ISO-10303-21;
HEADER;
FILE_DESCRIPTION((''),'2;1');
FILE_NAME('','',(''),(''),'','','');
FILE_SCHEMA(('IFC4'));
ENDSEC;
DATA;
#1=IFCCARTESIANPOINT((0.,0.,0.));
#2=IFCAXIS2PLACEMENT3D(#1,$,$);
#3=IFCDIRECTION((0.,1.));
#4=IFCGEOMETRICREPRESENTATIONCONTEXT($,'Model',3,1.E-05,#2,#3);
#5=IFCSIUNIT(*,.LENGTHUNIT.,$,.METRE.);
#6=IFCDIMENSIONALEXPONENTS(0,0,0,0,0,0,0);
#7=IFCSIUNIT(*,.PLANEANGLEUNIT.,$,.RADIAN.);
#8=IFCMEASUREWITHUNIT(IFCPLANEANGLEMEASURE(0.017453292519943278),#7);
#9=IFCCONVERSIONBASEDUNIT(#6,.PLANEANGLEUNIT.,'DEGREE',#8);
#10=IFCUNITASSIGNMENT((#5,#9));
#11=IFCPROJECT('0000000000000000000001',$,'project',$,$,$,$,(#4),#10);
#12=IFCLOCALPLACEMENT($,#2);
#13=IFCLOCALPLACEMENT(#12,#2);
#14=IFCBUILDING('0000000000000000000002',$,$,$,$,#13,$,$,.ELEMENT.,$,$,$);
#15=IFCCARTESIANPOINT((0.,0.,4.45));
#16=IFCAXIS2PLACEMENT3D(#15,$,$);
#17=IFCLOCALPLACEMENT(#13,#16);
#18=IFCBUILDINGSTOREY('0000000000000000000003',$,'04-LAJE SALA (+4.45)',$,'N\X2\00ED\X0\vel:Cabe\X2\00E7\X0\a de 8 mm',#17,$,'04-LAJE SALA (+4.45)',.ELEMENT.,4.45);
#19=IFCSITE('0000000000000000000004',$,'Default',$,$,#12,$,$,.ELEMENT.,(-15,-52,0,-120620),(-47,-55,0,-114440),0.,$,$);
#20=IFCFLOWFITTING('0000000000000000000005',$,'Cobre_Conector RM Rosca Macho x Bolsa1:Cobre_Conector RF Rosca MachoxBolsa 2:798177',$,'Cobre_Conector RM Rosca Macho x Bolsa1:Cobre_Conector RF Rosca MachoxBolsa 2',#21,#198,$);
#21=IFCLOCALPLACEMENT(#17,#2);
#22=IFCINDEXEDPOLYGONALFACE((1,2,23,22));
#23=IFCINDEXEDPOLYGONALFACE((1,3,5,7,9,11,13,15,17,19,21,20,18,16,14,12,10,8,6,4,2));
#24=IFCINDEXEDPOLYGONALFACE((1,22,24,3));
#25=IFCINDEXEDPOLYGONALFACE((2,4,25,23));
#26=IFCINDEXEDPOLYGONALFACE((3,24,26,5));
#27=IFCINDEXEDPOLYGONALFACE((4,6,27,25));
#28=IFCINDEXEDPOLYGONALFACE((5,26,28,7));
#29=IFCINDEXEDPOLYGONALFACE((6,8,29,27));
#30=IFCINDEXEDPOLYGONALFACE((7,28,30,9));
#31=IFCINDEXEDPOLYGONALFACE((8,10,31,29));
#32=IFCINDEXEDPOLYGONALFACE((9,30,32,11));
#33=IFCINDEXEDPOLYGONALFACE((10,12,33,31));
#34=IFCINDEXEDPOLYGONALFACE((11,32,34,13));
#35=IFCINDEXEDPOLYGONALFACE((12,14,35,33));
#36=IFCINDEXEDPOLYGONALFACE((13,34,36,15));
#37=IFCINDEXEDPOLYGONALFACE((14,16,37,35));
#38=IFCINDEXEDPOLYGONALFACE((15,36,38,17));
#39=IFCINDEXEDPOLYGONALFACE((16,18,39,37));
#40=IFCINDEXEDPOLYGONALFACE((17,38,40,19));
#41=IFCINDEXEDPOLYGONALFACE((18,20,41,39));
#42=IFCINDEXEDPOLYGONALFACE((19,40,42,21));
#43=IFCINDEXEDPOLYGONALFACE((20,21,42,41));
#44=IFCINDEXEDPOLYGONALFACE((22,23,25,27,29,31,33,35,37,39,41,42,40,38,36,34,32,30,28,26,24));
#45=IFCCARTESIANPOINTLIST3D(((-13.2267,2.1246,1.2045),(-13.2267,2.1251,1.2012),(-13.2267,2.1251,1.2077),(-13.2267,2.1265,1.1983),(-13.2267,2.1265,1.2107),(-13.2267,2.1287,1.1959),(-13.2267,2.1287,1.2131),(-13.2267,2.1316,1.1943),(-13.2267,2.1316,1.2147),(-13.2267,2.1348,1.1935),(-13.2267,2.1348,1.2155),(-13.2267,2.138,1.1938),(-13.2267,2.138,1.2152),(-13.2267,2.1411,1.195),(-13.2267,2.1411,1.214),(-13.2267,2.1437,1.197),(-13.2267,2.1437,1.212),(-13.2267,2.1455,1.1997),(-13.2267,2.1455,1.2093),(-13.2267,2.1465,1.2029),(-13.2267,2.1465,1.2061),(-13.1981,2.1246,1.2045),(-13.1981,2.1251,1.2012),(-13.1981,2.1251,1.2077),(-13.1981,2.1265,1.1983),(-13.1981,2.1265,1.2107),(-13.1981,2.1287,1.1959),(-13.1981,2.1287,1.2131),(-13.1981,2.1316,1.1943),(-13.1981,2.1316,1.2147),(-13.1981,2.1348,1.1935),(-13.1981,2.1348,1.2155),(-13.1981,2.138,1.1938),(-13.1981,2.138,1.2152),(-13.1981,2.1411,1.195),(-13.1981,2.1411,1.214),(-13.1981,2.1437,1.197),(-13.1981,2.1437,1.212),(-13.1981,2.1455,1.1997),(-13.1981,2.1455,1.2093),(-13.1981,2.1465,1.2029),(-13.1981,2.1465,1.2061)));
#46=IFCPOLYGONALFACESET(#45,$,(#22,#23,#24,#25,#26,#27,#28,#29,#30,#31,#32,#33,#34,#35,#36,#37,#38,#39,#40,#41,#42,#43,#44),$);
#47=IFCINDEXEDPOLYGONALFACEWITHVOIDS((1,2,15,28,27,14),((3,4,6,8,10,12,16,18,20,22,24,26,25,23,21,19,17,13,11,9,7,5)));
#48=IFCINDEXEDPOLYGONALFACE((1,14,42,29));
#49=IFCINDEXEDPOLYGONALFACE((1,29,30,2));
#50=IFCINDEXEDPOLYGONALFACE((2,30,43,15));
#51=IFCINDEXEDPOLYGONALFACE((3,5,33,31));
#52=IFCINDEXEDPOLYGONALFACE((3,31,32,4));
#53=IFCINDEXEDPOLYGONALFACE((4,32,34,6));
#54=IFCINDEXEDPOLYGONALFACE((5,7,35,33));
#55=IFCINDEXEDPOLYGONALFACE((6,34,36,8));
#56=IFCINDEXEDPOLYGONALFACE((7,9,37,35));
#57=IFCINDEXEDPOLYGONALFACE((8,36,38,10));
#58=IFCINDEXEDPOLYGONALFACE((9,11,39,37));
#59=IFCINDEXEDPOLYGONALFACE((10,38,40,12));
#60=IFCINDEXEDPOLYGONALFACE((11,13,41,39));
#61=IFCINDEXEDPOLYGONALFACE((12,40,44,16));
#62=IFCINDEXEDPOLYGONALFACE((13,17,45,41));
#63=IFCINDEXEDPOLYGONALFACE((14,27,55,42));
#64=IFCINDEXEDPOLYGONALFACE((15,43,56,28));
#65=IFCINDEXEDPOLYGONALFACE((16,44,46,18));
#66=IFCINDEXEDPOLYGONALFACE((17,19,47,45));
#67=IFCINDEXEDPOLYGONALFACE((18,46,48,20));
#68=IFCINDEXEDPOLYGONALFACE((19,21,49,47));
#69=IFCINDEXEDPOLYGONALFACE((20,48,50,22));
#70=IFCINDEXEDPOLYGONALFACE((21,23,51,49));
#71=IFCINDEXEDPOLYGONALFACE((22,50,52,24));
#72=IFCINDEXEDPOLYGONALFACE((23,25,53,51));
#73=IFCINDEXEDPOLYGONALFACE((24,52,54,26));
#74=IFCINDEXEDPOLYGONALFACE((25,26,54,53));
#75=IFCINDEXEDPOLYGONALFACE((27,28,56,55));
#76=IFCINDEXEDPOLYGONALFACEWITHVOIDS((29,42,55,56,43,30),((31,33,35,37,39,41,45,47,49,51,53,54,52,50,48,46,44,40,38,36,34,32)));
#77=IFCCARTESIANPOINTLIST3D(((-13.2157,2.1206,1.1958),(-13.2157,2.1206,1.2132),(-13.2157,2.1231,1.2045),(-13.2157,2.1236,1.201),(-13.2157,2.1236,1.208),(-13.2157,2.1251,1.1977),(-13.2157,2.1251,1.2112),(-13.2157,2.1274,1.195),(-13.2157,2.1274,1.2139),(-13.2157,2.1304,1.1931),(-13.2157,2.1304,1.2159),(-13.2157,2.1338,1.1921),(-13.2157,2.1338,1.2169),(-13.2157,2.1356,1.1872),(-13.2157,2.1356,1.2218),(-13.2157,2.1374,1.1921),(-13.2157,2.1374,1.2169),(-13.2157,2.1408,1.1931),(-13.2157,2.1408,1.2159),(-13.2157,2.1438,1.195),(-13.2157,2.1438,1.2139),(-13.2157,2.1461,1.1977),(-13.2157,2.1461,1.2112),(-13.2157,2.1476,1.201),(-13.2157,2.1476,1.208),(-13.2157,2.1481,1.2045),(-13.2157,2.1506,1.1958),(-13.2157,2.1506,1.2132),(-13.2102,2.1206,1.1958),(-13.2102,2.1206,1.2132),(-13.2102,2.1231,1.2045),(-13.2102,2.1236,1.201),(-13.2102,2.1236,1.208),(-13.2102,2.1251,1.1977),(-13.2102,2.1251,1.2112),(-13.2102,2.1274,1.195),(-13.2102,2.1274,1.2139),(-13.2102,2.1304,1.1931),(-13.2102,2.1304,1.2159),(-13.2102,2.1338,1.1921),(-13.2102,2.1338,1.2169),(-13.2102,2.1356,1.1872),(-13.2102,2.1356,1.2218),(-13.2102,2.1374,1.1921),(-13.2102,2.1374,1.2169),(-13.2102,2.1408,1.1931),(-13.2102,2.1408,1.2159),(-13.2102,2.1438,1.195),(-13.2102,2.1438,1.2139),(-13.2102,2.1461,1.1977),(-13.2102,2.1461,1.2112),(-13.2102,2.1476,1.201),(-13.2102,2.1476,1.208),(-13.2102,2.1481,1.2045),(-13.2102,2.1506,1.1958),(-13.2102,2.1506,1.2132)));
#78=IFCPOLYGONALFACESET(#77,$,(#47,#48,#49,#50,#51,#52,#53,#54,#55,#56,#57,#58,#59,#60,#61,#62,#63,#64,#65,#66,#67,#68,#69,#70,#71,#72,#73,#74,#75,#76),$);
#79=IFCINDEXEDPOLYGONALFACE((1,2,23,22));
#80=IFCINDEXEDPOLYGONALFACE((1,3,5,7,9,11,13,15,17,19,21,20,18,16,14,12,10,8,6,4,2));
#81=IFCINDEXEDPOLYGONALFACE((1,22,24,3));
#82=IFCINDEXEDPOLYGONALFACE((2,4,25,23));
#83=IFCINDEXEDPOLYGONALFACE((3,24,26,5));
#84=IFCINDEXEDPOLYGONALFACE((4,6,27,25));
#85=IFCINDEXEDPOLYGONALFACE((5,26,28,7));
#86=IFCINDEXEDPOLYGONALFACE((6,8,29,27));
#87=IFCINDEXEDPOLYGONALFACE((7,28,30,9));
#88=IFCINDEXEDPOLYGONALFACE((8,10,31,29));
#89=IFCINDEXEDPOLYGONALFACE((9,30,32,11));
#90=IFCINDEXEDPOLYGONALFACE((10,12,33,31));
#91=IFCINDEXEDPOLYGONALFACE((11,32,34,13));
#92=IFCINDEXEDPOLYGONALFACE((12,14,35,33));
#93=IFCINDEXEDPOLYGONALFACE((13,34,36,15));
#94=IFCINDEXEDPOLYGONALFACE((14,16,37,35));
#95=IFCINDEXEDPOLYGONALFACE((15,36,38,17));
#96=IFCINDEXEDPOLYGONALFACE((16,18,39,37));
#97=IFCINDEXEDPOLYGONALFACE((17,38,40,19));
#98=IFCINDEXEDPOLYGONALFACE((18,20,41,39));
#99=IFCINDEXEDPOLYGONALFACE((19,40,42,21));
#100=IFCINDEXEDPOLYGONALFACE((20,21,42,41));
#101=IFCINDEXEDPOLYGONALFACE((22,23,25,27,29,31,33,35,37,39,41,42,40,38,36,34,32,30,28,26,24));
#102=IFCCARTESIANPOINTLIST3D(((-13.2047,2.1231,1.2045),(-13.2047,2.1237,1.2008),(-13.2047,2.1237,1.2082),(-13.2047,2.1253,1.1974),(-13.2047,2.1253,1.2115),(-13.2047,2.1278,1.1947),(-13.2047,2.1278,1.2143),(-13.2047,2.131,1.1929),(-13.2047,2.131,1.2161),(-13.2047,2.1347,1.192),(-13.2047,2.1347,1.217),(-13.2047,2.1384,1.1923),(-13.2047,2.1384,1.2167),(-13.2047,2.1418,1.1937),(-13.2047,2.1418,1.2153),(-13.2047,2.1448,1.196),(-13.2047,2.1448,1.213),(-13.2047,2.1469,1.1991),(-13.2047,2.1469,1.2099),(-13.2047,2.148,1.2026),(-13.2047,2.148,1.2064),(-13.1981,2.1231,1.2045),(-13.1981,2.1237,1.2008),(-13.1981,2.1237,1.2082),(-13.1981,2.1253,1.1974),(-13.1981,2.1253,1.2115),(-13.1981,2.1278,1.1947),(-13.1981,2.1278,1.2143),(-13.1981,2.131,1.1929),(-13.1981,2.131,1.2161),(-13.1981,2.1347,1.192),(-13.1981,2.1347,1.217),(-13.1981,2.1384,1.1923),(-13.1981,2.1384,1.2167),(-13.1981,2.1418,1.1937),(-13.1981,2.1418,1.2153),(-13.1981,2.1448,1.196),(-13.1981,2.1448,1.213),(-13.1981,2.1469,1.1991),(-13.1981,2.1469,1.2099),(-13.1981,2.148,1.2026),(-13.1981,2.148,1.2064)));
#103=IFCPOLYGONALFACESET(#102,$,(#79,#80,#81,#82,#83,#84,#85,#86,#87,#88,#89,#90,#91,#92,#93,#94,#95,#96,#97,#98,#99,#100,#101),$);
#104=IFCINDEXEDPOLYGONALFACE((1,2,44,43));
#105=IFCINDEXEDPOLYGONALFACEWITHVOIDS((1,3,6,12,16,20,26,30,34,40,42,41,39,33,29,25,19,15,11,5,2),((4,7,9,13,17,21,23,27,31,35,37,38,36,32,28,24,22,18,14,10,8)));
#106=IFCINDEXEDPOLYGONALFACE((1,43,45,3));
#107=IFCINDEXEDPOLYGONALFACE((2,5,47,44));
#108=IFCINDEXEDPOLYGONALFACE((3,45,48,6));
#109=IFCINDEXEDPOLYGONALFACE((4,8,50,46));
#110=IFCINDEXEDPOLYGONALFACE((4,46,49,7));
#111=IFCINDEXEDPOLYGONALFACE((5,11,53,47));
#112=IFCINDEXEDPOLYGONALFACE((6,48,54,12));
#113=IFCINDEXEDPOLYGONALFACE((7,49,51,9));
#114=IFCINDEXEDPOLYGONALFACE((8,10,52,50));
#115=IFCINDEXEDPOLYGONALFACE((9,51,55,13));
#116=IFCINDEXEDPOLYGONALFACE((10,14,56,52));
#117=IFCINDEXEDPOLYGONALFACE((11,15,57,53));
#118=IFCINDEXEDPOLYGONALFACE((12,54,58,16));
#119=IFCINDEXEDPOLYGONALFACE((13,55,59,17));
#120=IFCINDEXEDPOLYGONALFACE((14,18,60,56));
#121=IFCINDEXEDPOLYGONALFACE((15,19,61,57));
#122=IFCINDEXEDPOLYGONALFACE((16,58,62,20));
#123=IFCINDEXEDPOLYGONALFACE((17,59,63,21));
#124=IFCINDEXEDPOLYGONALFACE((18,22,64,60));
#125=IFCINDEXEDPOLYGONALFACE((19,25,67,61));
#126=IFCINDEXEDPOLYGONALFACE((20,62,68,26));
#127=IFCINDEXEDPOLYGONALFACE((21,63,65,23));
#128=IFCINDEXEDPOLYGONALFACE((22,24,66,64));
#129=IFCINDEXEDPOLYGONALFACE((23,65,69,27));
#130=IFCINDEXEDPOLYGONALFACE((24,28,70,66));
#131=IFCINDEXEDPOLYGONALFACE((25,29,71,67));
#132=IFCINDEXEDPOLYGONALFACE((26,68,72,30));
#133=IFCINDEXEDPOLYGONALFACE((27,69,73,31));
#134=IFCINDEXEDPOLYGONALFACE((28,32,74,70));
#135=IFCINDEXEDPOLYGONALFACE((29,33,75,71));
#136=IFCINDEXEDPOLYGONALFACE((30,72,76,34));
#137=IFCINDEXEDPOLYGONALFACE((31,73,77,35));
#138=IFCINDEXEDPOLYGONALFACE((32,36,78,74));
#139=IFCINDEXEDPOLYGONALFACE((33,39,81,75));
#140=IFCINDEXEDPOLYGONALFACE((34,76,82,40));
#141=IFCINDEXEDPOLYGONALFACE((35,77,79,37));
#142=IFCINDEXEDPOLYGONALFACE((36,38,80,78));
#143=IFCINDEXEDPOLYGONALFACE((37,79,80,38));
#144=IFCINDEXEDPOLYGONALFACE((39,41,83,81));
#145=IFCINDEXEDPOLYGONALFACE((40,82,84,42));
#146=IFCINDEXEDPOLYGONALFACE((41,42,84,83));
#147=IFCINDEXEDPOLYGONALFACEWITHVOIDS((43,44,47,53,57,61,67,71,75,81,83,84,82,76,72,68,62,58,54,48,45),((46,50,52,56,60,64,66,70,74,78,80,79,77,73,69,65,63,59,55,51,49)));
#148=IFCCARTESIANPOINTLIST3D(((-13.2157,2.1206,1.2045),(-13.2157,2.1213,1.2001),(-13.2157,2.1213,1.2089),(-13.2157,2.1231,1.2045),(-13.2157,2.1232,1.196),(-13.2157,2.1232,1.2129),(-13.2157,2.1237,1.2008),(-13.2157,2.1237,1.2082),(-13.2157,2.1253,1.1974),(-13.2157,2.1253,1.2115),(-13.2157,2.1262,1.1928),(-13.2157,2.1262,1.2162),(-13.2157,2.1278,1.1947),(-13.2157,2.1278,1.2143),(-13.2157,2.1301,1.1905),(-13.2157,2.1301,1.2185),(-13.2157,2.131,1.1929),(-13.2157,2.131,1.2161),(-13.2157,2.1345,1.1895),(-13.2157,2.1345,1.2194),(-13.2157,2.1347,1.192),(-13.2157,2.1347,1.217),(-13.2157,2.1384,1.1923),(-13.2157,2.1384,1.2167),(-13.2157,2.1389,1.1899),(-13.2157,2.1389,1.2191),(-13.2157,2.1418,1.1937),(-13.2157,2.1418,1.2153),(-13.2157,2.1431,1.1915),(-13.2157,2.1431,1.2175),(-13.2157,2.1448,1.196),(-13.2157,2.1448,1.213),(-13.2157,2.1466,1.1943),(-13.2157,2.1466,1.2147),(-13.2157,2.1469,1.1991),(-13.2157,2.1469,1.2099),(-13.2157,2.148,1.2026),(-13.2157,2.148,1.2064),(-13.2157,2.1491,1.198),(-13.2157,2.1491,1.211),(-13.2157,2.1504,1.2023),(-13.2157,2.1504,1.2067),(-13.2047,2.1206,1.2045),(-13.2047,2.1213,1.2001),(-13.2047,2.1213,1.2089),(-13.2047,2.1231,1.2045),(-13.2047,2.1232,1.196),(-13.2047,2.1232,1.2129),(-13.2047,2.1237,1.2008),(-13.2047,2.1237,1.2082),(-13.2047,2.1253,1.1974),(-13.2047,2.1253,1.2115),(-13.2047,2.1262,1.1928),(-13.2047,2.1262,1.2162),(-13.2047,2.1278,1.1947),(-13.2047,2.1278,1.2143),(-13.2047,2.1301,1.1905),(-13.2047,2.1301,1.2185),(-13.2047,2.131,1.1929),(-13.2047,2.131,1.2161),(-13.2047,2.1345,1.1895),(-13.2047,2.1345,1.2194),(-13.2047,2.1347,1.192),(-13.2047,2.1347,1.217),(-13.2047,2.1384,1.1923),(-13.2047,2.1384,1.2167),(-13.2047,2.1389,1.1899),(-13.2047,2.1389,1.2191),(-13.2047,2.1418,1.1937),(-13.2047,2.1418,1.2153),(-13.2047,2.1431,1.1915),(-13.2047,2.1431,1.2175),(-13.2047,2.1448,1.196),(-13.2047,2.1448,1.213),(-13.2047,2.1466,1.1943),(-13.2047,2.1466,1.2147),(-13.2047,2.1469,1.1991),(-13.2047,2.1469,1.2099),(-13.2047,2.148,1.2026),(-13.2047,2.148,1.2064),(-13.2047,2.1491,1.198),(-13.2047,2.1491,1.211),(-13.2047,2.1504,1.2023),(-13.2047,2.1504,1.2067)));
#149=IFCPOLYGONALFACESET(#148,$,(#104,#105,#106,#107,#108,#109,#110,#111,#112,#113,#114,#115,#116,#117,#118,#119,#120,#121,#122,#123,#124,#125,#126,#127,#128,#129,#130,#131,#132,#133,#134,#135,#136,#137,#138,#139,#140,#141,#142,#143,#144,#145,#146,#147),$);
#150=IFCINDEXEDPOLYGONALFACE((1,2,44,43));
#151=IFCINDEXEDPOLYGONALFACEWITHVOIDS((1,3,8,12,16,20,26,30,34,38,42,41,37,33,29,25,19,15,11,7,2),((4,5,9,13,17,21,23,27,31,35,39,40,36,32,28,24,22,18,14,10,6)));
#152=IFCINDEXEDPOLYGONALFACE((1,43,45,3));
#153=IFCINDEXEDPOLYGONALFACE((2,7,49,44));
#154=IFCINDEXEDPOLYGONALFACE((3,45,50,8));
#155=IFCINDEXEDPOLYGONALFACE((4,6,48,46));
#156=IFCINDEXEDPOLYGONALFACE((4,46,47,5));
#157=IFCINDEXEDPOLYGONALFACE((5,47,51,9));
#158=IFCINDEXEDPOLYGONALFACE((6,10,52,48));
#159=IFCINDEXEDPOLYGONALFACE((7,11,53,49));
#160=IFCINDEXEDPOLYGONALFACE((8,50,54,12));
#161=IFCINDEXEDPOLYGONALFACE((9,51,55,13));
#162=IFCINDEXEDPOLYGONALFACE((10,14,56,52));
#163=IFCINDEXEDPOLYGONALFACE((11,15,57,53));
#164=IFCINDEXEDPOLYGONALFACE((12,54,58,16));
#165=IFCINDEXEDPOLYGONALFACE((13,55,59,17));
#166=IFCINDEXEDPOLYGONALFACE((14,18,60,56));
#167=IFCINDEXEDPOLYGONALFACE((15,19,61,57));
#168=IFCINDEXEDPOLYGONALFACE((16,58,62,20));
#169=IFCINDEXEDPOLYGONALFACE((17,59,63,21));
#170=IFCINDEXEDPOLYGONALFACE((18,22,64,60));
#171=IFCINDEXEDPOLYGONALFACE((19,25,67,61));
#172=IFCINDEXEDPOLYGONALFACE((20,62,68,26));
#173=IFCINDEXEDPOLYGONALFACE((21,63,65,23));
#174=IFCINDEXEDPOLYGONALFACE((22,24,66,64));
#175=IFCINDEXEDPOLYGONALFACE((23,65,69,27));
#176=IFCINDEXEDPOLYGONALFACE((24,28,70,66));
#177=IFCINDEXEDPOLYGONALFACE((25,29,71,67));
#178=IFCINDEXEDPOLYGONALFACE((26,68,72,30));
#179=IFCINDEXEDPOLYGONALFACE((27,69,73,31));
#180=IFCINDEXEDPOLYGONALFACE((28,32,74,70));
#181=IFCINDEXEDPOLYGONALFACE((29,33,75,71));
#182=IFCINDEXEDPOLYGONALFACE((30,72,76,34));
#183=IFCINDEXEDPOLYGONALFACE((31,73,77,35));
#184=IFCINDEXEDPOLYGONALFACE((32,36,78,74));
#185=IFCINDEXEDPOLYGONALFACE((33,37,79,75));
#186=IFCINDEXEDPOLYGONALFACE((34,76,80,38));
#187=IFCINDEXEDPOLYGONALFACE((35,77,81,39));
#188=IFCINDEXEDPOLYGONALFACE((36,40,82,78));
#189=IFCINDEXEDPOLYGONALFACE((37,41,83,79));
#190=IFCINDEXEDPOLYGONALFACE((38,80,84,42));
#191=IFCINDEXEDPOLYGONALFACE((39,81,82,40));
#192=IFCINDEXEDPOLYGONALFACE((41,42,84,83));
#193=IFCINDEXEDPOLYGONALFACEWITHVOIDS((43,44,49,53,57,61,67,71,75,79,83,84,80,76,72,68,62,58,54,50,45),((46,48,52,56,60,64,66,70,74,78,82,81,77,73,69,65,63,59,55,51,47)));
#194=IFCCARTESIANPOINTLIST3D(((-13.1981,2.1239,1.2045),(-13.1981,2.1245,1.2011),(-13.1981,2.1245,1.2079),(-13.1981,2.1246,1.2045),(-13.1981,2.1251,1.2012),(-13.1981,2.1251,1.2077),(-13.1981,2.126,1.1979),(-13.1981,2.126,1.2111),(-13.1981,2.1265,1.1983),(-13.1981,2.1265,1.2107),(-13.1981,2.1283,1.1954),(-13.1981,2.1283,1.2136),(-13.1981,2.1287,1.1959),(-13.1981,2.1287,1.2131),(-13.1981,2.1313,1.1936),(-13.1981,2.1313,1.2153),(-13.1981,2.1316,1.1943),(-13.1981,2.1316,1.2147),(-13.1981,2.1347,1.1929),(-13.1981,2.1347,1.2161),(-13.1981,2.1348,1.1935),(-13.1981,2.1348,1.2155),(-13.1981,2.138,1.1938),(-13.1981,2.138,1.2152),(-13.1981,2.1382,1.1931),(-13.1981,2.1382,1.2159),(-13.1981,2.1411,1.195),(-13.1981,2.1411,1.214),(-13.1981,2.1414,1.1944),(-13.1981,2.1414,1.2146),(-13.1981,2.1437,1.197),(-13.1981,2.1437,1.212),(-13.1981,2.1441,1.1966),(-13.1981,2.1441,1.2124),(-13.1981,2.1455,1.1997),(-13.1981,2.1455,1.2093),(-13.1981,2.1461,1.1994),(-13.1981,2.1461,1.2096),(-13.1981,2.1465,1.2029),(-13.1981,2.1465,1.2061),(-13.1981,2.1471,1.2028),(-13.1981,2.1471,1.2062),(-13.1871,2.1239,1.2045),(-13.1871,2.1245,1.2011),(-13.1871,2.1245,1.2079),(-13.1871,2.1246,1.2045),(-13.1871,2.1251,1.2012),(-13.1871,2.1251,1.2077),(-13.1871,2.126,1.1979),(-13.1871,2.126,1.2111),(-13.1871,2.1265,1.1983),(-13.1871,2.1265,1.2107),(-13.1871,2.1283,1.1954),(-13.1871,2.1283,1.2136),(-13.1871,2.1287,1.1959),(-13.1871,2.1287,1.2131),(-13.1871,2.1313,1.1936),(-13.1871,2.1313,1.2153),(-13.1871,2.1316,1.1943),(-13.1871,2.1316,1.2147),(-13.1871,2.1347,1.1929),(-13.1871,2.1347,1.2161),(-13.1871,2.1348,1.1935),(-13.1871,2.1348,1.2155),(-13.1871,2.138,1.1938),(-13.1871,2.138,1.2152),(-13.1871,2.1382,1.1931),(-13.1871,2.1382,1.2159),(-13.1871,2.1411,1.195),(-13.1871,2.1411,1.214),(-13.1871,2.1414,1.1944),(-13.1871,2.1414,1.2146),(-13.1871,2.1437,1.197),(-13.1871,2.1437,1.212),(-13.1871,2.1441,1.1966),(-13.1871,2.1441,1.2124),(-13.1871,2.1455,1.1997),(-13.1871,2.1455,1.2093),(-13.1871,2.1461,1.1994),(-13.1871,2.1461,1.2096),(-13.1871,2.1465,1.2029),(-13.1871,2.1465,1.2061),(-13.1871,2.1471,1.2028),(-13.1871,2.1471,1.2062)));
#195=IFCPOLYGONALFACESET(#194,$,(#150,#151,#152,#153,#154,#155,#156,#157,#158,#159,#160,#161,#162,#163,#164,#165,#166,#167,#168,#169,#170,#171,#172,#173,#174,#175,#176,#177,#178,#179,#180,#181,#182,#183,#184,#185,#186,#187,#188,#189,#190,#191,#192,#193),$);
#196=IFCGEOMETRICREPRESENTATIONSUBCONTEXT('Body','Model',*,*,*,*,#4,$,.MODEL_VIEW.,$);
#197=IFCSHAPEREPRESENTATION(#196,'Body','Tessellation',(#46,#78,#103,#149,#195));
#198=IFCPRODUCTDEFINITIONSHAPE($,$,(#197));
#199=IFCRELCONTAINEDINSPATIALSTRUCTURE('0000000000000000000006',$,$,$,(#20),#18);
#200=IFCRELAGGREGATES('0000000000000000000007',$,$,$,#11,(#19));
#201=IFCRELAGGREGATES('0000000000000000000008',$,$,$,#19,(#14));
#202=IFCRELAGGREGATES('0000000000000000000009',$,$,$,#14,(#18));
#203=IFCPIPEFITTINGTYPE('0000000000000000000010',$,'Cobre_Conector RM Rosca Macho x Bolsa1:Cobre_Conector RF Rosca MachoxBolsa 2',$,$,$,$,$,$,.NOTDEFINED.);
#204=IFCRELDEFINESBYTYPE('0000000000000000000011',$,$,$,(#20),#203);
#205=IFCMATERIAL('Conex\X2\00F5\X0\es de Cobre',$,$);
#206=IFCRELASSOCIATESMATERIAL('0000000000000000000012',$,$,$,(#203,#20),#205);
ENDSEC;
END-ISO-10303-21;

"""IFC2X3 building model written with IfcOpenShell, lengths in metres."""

from ifc_helpers import new_model, entity, si_unit, converted_unit, direction, frame, frame_2d, origin, place, context, subcontext, project, spatial, polyline, circle_curve, parameter, trimmed, segment, composite_curve, circle, hollow_circle, outline, extrude, source, transform, mapped, material, type_object, type_shapes, element, save


model = new_model("IFC2X3")

# Units and contexts
model_context = context("Model", 3, precision=1e-05, world=origin(), true_north=direction((0.0, 1.0)))
body_context = subcontext(model_context, "Body", "Model", "MODEL_VIEW")
ifc_project = project(units=[si_unit("LENGTHUNIT", "METRE"), converted_unit("PLANEANGLEUNIT", "DEGREE", entity("IfcPlaneAngleMeasure", 0.017453292519943278), si_unit("PLANEANGLEUNIT", "RADIAN"), dimensions=[0, 0, 0, 0, 0, 0, 0])], contexts=[model_context])

# Site, building, storey
site_placement = place(None, origin())
site = spatial("IfcSite", under=ifc_project, at=site_placement, Name="Default", CompositionType="ELEMENT", RefLatitude=(-15, -52, 0, -120620), RefLongitude=(-47, -55, 0, -114440), RefElevation=0.0)
building_placement = place(site_placement, origin())
building = spatial("IfcBuilding", under=site, at=building_placement, CompositionType="ELEMENT")
storey_placement = place(building_placement, frame((0.0, 0.0, 4.45)))
storey = spatial("IfcBuildingStorey", under=building, at=storey_placement, Name="04-LAJE SALA (+4.45)", ObjectType="Nível:Cabeça de 8 mm", LongName="04-LAJE SALA (+4.45)", CompositionType="ELEMENT", Elevation=4.45)

# Flow fitting
ifc_material_1 = material(Name="Conexões de Cobre")
pipe_fitting_type_1 = type_object("IfcPipeFittingType", Name="Cobre_Conector RM Rosca Macho x Bolsa1:Cobre_Conector RF Rosca MachoxBolsa 2", PredefinedType="NOTDEFINED", material=ifc_material_1)
shared_shape_1 = source(origin(), body_context, "Body", "SweptSolid", [
    extrude(circle(Radius=0.011, at=frame_2d((0.0, 0.0), x_axis=(1.0, 0.0))), frame((0.011, 0.0, 0.0), z_axis=(1.0, 0.0, 0.0), x_axis=(0.0, 1.0, 0.0)), (0.0, 0.0, 1.0), 0.0286),
    extrude(outline(polyline([(-0.0087, -0.015), (0.0087, -0.015), (0.0173, 0.0), (0.0087, 0.015), (-0.0087, 0.015), (-0.0173, 0.0), (-0.0087, -0.015)]), holes=[composite_curve([segment(trimmed(circle_curve(frame_2d((0.0, 0.0), x_axis=(0.0, 1.0)), 0.0125), [parameter(0.0)], [parameter(180.0)], True, "PARAMETER"), False, "CONTINUOUS"), segment(trimmed(circle_curve(frame_2d((0.0, 0.0), x_axis=(0.0, 1.0)), 0.0125), [parameter(180.0)], [parameter(0.0)], True, "PARAMETER"), False, "CONTINUOUS")], self_intersect=False)]), frame((0.0231, 0.0, 0.0), z_axis=(1.0, 0.0, 0.0), x_axis=(0.0, 0.0, -1.0)), (0.0, 0.0, 1.0), 0.0055),
    extrude(circle(Radius=0.0125, at=frame_2d((0.0, 0.0), x_axis=(1.0, 0.0))), frame((0.011, 0.0, 0.0), z_axis=(1.0, 0.0, 0.0), x_axis=(0.0, 1.0, 0.0)), (0.0, 0.0, 1.0), 0.0066),
    extrude(hollow_circle(Radius=0.015, WallThickness=0.0025, at=frame_2d((0.0, 0.0), x_axis=(1.0, 0.0))), frame((0.0176, 0.0, 0.0), z_axis=(1.0, 0.0, 0.0), x_axis=(0.0, 1.0, 0.0)), (0.0, 0.0, 1.0), 0.011),
    extrude(hollow_circle(Radius=0.0117, WallThickness=0.0007, at=frame_2d((0.0, 0.0), x_axis=(1.0, 0.0))), frame((0.0, 0.0, 0.0), z_axis=(1.0, 0.0, 0.0), x_axis=(0.0, 1.0, 0.0)), (0.0, 0.0, 1.0), 0.011),
])
type_shapes(pipe_fitting_type_1, [shared_shape_1])
flow_fitting_1_placement = place(storey_placement, frame((-13.1871, 2.1356, 1.2045), z_axis=(0.0, 0.0, 1.0), x_axis=(-1.0, 0.0, 0.0)))
element("IfcFlowFitting", 1, at=flow_fitting_1_placement, inside=storey, type_object=pipe_fitting_type_1, material=ifc_material_1, Name="Cobre_Conector RM Rosca Macho x Bolsa1:Cobre_Conector RF Rosca MachoxBolsa 2:798177", ObjectType="Cobre_Conector RM Rosca Macho x Bolsa1:Cobre_Conector RF Rosca MachoxBolsa 2", context=body_context, shape_type="MappedRepresentation", body=[
    mapped(shared_shape_1, transform((0.0, 0.0, 0.0), scale=1.0)),
])

save(model, "model.ifc")
